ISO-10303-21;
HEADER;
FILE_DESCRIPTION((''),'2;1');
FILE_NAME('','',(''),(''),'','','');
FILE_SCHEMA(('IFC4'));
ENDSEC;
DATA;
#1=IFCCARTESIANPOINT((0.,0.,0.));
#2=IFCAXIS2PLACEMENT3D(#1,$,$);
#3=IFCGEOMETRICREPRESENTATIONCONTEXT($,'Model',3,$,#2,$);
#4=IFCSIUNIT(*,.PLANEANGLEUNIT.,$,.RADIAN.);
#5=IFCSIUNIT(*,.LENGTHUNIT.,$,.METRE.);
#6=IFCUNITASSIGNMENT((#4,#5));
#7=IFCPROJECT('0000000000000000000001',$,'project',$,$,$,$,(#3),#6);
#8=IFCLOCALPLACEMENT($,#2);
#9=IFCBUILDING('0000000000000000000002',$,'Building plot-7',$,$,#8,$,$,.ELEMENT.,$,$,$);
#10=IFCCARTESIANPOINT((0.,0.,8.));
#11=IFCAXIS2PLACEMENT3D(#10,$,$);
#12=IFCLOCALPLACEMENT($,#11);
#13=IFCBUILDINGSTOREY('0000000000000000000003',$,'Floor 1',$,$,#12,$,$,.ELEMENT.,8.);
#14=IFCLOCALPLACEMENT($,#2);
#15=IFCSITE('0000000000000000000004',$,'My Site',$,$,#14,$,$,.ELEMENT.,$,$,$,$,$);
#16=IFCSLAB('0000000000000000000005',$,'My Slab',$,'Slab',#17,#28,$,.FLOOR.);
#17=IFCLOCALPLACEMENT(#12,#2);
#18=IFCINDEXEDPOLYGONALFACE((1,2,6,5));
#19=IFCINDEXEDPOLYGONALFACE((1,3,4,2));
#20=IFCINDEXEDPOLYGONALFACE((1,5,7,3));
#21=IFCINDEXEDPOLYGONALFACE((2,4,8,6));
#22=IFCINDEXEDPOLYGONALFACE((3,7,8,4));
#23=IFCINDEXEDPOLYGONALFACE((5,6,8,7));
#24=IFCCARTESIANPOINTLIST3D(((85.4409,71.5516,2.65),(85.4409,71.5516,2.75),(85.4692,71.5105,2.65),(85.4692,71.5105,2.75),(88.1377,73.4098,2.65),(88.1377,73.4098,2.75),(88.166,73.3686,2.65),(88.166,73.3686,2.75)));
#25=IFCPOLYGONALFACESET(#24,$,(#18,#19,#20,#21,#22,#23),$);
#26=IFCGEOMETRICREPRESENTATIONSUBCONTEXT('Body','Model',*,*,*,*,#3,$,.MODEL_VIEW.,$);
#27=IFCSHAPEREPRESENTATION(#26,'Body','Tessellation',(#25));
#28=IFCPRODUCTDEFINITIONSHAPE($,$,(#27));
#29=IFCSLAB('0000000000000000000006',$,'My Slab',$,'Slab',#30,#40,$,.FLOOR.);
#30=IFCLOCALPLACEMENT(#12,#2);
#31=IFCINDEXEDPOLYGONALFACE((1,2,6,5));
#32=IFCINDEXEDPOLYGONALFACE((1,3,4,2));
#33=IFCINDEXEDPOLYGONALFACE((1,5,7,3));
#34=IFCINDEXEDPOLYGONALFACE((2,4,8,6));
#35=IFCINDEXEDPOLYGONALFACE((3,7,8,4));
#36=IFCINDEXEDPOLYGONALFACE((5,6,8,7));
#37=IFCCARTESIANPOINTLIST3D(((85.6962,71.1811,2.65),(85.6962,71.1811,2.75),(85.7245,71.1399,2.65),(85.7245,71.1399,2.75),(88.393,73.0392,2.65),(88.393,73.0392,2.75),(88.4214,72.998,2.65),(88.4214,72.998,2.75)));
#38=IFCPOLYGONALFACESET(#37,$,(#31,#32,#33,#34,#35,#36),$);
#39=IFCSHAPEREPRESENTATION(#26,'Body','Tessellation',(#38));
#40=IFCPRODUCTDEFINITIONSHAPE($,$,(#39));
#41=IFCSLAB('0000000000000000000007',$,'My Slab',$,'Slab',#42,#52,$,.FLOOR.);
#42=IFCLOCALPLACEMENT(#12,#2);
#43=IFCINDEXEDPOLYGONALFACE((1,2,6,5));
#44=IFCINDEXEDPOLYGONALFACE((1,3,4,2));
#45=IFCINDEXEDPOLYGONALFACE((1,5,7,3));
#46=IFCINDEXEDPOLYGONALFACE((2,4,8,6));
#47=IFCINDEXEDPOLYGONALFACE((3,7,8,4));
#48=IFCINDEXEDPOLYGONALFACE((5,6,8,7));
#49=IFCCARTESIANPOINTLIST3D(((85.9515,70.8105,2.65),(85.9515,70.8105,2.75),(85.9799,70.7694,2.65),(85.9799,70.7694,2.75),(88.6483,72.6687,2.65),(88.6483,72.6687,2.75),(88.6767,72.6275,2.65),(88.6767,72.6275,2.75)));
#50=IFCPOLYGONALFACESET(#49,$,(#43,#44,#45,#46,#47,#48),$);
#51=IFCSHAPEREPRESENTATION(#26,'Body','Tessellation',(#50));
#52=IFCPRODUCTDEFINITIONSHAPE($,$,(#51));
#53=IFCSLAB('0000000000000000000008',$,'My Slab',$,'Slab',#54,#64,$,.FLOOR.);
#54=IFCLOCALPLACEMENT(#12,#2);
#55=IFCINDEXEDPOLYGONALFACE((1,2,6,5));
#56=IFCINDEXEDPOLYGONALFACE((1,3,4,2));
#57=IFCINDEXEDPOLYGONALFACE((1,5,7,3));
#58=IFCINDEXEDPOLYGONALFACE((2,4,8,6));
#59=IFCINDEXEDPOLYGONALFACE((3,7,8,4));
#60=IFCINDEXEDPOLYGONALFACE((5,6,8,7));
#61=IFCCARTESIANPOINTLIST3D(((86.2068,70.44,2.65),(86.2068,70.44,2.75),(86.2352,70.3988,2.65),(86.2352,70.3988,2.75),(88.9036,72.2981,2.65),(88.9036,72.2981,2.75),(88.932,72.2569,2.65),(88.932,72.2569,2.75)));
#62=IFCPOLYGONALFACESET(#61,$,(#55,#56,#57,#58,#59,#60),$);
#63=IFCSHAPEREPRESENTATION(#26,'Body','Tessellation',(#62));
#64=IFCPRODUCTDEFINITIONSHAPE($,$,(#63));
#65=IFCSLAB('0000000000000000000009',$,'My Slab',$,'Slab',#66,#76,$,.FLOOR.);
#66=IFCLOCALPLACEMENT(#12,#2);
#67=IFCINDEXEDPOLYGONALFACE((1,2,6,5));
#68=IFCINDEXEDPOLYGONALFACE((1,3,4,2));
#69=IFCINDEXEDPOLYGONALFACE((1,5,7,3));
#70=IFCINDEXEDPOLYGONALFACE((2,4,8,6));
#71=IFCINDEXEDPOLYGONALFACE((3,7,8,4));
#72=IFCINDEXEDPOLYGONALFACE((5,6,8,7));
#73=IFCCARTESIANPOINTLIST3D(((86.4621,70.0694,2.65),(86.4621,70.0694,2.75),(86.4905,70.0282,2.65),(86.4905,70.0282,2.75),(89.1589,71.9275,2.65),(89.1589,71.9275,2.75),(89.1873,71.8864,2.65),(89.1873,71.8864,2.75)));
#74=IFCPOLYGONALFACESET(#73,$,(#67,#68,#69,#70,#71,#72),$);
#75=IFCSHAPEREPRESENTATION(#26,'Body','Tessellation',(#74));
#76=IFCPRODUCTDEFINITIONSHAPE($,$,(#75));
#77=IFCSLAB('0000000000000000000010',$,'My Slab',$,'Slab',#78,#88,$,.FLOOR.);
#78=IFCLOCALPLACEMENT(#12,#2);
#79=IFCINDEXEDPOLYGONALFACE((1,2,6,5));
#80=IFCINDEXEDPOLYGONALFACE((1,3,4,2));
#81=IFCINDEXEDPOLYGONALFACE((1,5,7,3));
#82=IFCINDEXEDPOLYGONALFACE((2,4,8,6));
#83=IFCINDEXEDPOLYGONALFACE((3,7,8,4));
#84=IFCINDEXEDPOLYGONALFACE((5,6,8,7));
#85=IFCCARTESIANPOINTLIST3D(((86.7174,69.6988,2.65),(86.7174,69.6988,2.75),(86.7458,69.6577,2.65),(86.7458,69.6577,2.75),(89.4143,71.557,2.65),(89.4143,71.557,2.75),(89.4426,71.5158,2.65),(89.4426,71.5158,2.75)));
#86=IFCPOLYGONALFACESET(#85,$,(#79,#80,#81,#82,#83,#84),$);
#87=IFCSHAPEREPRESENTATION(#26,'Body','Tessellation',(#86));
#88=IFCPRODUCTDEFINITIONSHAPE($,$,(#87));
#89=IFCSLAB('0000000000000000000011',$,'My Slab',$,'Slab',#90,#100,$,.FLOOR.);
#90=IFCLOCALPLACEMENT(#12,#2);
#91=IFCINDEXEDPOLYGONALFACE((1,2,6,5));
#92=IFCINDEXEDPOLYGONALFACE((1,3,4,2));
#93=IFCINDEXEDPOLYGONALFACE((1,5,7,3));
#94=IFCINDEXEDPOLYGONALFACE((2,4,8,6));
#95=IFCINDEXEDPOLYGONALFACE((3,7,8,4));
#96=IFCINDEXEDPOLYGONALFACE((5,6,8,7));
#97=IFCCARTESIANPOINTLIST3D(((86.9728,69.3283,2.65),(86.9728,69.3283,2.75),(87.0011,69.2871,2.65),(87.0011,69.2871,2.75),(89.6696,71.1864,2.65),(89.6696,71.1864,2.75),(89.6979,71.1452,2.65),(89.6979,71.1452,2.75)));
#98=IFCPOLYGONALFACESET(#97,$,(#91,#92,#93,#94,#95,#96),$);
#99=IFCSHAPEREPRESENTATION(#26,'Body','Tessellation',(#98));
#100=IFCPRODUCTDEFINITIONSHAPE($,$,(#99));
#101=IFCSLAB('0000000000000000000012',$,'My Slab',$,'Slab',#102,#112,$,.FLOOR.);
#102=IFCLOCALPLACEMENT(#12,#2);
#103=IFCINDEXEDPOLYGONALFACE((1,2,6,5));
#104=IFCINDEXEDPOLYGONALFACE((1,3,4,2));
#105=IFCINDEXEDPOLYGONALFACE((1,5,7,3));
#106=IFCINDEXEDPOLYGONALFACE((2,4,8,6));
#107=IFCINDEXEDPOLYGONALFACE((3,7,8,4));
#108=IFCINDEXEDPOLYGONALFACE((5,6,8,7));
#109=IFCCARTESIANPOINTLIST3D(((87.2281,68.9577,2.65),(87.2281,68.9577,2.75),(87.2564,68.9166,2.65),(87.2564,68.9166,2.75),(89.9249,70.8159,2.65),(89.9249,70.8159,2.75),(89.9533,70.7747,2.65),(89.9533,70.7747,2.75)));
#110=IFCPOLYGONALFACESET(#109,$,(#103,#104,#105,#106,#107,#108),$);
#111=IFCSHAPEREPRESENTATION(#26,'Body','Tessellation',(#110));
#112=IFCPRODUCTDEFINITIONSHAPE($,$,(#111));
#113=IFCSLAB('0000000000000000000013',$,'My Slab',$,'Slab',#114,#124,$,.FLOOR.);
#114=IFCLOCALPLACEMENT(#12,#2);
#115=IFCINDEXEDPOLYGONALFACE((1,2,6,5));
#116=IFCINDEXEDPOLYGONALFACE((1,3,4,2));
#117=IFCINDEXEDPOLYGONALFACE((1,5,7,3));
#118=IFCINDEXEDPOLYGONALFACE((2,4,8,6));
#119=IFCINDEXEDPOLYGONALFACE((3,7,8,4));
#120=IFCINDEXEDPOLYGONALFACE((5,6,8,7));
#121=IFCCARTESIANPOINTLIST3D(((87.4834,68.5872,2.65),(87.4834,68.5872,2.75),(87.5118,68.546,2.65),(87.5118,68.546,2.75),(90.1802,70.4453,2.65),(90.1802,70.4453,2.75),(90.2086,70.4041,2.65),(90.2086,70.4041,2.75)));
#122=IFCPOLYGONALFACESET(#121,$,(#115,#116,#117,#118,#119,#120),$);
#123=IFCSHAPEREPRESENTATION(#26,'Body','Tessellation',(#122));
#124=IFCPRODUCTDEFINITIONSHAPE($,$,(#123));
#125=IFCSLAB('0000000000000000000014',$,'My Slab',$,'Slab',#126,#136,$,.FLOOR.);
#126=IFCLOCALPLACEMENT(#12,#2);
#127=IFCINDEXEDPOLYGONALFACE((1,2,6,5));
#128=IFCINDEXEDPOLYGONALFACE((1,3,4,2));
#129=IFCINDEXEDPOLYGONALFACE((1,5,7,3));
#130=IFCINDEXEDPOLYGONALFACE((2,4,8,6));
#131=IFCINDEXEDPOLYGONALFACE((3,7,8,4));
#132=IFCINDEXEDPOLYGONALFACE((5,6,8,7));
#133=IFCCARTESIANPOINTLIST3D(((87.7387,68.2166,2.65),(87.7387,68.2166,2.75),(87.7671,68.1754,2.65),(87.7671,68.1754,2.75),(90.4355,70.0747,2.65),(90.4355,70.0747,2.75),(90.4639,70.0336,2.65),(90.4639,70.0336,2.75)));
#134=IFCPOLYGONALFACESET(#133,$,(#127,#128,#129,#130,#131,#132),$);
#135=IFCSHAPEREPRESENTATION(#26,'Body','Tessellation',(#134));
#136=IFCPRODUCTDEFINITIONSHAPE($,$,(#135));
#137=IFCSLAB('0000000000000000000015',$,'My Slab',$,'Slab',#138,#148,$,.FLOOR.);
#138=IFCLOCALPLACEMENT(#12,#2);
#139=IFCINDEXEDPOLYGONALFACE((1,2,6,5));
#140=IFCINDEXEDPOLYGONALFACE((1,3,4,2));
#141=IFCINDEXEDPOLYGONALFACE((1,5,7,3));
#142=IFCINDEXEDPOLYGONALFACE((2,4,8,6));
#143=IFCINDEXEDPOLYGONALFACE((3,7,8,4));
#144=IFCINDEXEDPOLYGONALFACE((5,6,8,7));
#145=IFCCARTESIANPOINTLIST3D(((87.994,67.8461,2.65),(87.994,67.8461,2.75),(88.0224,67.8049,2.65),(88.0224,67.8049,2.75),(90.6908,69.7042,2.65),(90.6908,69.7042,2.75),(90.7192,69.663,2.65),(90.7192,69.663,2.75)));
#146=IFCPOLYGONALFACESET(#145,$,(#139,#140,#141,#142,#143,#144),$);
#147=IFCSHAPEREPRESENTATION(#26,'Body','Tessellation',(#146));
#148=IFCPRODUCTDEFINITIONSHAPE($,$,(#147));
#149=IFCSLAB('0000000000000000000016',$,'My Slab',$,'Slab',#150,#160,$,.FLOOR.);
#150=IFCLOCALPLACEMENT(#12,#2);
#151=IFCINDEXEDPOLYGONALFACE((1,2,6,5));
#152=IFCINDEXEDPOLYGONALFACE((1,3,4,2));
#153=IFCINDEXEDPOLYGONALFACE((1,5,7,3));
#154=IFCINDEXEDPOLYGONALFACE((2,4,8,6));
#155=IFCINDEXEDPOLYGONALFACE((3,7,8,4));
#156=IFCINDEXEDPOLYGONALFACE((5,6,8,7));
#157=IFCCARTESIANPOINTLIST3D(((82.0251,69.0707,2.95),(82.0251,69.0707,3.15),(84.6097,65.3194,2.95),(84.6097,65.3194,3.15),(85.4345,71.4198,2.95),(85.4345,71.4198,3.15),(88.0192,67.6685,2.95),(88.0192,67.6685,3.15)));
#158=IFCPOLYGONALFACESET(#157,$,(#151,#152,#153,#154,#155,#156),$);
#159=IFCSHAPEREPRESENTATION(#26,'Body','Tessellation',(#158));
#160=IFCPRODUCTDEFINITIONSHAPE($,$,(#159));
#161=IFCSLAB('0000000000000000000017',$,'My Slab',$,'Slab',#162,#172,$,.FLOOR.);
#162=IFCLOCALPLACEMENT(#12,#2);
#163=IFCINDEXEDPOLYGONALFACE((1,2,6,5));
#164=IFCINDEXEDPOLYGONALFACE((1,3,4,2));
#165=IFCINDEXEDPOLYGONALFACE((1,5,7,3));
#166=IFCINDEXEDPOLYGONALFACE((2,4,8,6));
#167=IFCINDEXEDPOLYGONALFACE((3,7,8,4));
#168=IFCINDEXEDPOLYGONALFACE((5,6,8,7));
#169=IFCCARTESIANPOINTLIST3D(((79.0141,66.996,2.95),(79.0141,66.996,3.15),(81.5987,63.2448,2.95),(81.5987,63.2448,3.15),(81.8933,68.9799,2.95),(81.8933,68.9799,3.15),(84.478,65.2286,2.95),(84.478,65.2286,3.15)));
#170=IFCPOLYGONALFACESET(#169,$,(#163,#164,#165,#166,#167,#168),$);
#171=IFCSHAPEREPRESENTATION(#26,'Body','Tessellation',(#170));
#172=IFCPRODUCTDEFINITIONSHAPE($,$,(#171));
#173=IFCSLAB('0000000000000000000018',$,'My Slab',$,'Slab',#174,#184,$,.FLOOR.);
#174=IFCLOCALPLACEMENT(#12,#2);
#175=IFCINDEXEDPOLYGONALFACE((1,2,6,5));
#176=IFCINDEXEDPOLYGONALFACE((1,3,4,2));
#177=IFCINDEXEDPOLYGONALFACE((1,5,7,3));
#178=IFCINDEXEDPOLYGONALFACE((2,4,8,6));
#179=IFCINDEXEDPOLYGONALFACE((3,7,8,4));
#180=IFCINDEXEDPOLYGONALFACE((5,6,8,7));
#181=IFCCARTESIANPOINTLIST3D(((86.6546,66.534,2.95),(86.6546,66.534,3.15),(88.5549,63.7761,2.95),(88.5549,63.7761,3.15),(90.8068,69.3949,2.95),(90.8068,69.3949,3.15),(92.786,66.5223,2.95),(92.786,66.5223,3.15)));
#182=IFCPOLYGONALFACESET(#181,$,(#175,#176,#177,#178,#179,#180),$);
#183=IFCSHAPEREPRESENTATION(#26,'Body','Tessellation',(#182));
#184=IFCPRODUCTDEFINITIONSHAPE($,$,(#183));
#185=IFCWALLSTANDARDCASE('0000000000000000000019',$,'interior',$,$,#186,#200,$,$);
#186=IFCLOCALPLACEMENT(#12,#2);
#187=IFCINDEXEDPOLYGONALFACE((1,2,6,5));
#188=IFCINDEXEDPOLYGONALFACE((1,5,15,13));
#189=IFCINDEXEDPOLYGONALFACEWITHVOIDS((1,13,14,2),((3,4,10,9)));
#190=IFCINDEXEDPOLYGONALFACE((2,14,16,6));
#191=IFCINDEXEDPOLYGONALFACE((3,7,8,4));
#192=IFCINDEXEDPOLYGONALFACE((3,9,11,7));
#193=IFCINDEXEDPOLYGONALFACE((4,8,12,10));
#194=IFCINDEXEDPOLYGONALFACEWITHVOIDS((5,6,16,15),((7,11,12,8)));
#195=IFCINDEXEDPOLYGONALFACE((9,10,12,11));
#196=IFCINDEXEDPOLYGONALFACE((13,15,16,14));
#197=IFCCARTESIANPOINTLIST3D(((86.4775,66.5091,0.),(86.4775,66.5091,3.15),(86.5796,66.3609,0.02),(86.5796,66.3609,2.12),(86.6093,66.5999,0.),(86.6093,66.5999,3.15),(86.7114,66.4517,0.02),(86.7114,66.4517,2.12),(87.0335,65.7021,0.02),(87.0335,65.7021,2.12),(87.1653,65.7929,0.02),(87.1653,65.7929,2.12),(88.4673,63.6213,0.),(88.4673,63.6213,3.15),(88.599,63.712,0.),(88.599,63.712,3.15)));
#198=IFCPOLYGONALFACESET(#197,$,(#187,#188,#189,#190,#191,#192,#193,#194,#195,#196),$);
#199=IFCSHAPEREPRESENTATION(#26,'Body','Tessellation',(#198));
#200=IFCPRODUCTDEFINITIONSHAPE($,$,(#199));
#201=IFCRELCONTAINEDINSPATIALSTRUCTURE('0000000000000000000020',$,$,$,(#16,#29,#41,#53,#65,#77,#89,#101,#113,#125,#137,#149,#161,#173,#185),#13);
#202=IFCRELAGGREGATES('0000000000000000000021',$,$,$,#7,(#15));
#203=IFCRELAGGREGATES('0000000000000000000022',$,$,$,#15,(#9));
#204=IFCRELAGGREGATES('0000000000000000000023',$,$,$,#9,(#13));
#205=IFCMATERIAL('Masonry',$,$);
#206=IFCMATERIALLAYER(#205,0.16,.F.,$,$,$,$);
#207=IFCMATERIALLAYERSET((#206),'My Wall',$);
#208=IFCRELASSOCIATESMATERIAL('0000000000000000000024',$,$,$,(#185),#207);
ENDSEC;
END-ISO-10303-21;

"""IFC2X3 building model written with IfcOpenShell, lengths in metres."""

from ifc_helpers import new_model, si_unit, frame, origin, place, context, subcontext, project, spatial, polyline, outline, extrude, material, layer, layer_set, layer_usage, element, save


model = new_model("IFC2X3")

# Units and contexts
model_context = context("Model", 3, world=origin())
body_context = subcontext(model_context, "Body", "Model", "MODEL_VIEW")
ifc_project = project(units=[si_unit("PLANEANGLEUNIT", "RADIAN"), si_unit("LENGTHUNIT", "METRE")], contexts=[model_context])

# Site, building, storey
site_placement = place(None, origin())
site = spatial("IfcSite", under=ifc_project, at=site_placement, Name="My Site", CompositionType="ELEMENT")
building_placement = place(None, origin())
building = spatial("IfcBuilding", under=site, at=building_placement, Name="Building plot-7", CompositionType="ELEMENT")
storey_placement = place(None, frame((0.0, 0.0, 8.0)))
storey = spatial("IfcBuildingStorey", under=building, at=storey_placement, Name="Floor 1", CompositionType="ELEMENT", Elevation=8.0)

# Slabs
slab_1_placement = place(storey_placement, frame((0.0, 0.0, 2.65)))
element("IfcSlab", 1, at=slab_1_placement, inside=storey, Name="My Slab", ObjectType="Slab", PredefinedType="FLOOR", context=body_context, shape_type="SweptSolid", body=[
    extrude(outline(polyline([(85.4409, 71.5516), (85.4692, 71.5105), (88.166, 73.3686), (88.1377, 73.4098), (85.4409, 71.5516)])), origin(), (0.0, 0.0, 1.0), 0.1),
])
slab_2_placement = place(storey_placement, frame((0.0, 0.0, 2.65)))
element("IfcSlab", 2, at=slab_2_placement, inside=storey, Name="My Slab", ObjectType="Slab", PredefinedType="FLOOR", context=body_context, shape_type="SweptSolid", body=[
    extrude(outline(polyline([(85.6962, 71.1811), (85.7245, 71.1399), (88.4214, 72.998), (88.393, 73.0392), (85.6962, 71.1811)])), origin(), (0.0, 0.0, 1.0), 0.1),
])
slab_3_placement = place(storey_placement, frame((0.0, 0.0, 2.65)))
element("IfcSlab", 3, at=slab_3_placement, inside=storey, Name="My Slab", ObjectType="Slab", PredefinedType="FLOOR", context=body_context, shape_type="SweptSolid", body=[
    extrude(outline(polyline([(85.9515, 70.8105), (85.9799, 70.7694), (88.6767, 72.6275), (88.6483, 72.6687), (85.9515, 70.8105)])), origin(), (0.0, 0.0, 1.0), 0.1),
])
slab_4_placement = place(storey_placement, frame((0.0, 0.0, 2.65)))
element("IfcSlab", 4, at=slab_4_placement, inside=storey, Name="My Slab", ObjectType="Slab", PredefinedType="FLOOR", context=body_context, shape_type="SweptSolid", body=[
    extrude(outline(polyline([(86.2068, 70.44), (86.2352, 70.3988), (88.932, 72.2569), (88.9036, 72.2981), (86.2068, 70.44)])), origin(), (0.0, 0.0, 1.0), 0.1),
])
slab_5_placement = place(storey_placement, frame((0.0, 0.0, 2.65)))
element("IfcSlab", 5, at=slab_5_placement, inside=storey, Name="My Slab", ObjectType="Slab", PredefinedType="FLOOR", context=body_context, shape_type="SweptSolid", body=[
    extrude(outline(polyline([(86.4621, 70.0694), (86.4905, 70.0282), (89.1873, 71.8864), (89.1589, 71.9275), (86.4621, 70.0694)])), origin(), (0.0, 0.0, 1.0), 0.1),
])
slab_6_placement = place(storey_placement, frame((0.0, 0.0, 2.65)))
element("IfcSlab", 6, at=slab_6_placement, inside=storey, Name="My Slab", ObjectType="Slab", PredefinedType="FLOOR", context=body_context, shape_type="SweptSolid", body=[
    extrude(outline(polyline([(86.7174, 69.6988), (86.7458, 69.6577), (89.4426, 71.5158), (89.4143, 71.557), (86.7174, 69.6988)])), origin(), (0.0, 0.0, 1.0), 0.1),
])
slab_7_placement = place(storey_placement, frame((0.0, 0.0, 2.65)))
element("IfcSlab", 7, at=slab_7_placement, inside=storey, Name="My Slab", ObjectType="Slab", PredefinedType="FLOOR", context=body_context, shape_type="SweptSolid", body=[
    extrude(outline(polyline([(86.9728, 69.3283), (87.0011, 69.2871), (89.6979, 71.1452), (89.6696, 71.1864), (86.9728, 69.3283)])), origin(), (0.0, 0.0, 1.0), 0.1),
])
slab_8_placement = place(storey_placement, frame((0.0, 0.0, 2.65)))
element("IfcSlab", 8, at=slab_8_placement, inside=storey, Name="My Slab", ObjectType="Slab", PredefinedType="FLOOR", context=body_context, shape_type="SweptSolid", body=[
    extrude(outline(polyline([(87.2281, 68.9577), (87.2564, 68.9166), (89.9533, 70.7747), (89.9249, 70.8159), (87.2281, 68.9577)])), origin(), (0.0, 0.0, 1.0), 0.1),
])
slab_9_placement = place(storey_placement, frame((0.0, 0.0, 2.65)))
element("IfcSlab", 9, at=slab_9_placement, inside=storey, Name="My Slab", ObjectType="Slab", PredefinedType="FLOOR", context=body_context, shape_type="SweptSolid", body=[
    extrude(outline(polyline([(87.4834, 68.5872), (87.5118, 68.546), (90.2086, 70.4041), (90.1802, 70.4453), (87.4834, 68.5872)])), origin(), (0.0, 0.0, 1.0), 0.1),
])
slab_10_placement = place(storey_placement, frame((0.0, 0.0, 2.65)))
element("IfcSlab", 10, at=slab_10_placement, inside=storey, Name="My Slab", ObjectType="Slab", PredefinedType="FLOOR", context=body_context, shape_type="SweptSolid", body=[
    extrude(outline(polyline([(87.7387, 68.2166), (87.7671, 68.1754), (90.4639, 70.0336), (90.4355, 70.0747), (87.7387, 68.2166)])), origin(), (0.0, 0.0, 1.0), 0.1),
])
slab_11_placement = place(storey_placement, frame((0.0, 0.0, 2.65)))
element("IfcSlab", 11, at=slab_11_placement, inside=storey, Name="My Slab", ObjectType="Slab", PredefinedType="FLOOR", context=body_context, shape_type="SweptSolid", body=[
    extrude(outline(polyline([(87.994, 67.8461), (88.0224, 67.8049), (90.7192, 69.663), (90.6908, 69.7042), (87.994, 67.8461)])), origin(), (0.0, 0.0, 1.0), 0.1),
])
slab_12_placement = place(storey_placement, frame((0.0, 0.0, 2.95)))
element("IfcSlab", 12, at=slab_12_placement, inside=storey, Name="My Slab", ObjectType="Slab", PredefinedType="FLOOR", context=body_context, shape_type="SweptSolid", body=[
    extrude(outline(polyline([(84.6097, 65.3194), (88.0192, 67.6685), (85.4345, 71.4198), (82.0251, 69.0707), (84.6097, 65.3194)])), origin(), (0.0, 0.0, 1.0), 0.2),
])
slab_13_placement = place(storey_placement, frame((0.0, 0.0, 2.95)))
element("IfcSlab", 13, at=slab_13_placement, inside=storey, Name="My Slab", ObjectType="Slab", PredefinedType="FLOOR", context=body_context, shape_type="SweptSolid", body=[
    extrude(outline(polyline([(81.8933, 68.9799), (79.0141, 66.996), (81.5987, 63.2448), (84.478, 65.2286), (81.8933, 68.9799)])), origin(), (0.0, 0.0, 1.0), 0.2),
])
slab_14_placement = place(storey_placement, frame((0.0, 0.0, 2.95)))
element("IfcSlab", 14, at=slab_14_placement, inside=storey, Name="My Slab", ObjectType="Slab", PredefinedType="FLOOR", context=body_context, shape_type="SweptSolid", body=[
    extrude(outline(polyline([(88.5549, 63.7761), (92.786, 66.5223), (90.8068, 69.3949), (86.6546, 66.534), (88.5549, 63.7761)])), origin(), (0.0, 0.0, 1.0), 0.2),
])

# Wall, opening
ifc_material = material(Name="Masonry")
ifc_layer = layer(ifc_material, 0.16, ventilated=False)
ifc_layer_set = layer_set([ifc_layer], Name="My Wall")
ifc_layer_usage = layer_usage(ifc_layer_set, "AXIS2", "NEGATIVE", 0.08)
wall_1_placement = place(storey_placement, origin())
wall_1 = element("IfcWallStandardCase", 15, at=wall_1_placement, inside=storey, material=ifc_layer_usage, Name="interior", context=body_context, shape_type="SweptSolid", body=[
    extrude(outline(polyline([(86.6093, 66.5999), (86.4775, 66.5091), (88.4673, 63.6213), (88.599, 63.712), (86.6093, 66.5999)])), origin(), (0.0, 0.0, 1.0), 3.15),
])
opening_placement = place(storey_placement, frame((0.0, 0.0, 0.02)))
element("IfcOpeningElement", 16, at=opening_placement, cuts=wall_1, ObjectType="Opening", context=body_context, shape_type="SweptSolid", body=[
    extrude(outline(polyline([(86.5796, 66.3609), (87.0335, 65.7021), (87.1653, 65.7929), (86.7114, 66.4517), (86.5796, 66.3609)])), origin(), (0.0, 0.0, 1.0), 2.1),
])

save(model, "model.ifc")
